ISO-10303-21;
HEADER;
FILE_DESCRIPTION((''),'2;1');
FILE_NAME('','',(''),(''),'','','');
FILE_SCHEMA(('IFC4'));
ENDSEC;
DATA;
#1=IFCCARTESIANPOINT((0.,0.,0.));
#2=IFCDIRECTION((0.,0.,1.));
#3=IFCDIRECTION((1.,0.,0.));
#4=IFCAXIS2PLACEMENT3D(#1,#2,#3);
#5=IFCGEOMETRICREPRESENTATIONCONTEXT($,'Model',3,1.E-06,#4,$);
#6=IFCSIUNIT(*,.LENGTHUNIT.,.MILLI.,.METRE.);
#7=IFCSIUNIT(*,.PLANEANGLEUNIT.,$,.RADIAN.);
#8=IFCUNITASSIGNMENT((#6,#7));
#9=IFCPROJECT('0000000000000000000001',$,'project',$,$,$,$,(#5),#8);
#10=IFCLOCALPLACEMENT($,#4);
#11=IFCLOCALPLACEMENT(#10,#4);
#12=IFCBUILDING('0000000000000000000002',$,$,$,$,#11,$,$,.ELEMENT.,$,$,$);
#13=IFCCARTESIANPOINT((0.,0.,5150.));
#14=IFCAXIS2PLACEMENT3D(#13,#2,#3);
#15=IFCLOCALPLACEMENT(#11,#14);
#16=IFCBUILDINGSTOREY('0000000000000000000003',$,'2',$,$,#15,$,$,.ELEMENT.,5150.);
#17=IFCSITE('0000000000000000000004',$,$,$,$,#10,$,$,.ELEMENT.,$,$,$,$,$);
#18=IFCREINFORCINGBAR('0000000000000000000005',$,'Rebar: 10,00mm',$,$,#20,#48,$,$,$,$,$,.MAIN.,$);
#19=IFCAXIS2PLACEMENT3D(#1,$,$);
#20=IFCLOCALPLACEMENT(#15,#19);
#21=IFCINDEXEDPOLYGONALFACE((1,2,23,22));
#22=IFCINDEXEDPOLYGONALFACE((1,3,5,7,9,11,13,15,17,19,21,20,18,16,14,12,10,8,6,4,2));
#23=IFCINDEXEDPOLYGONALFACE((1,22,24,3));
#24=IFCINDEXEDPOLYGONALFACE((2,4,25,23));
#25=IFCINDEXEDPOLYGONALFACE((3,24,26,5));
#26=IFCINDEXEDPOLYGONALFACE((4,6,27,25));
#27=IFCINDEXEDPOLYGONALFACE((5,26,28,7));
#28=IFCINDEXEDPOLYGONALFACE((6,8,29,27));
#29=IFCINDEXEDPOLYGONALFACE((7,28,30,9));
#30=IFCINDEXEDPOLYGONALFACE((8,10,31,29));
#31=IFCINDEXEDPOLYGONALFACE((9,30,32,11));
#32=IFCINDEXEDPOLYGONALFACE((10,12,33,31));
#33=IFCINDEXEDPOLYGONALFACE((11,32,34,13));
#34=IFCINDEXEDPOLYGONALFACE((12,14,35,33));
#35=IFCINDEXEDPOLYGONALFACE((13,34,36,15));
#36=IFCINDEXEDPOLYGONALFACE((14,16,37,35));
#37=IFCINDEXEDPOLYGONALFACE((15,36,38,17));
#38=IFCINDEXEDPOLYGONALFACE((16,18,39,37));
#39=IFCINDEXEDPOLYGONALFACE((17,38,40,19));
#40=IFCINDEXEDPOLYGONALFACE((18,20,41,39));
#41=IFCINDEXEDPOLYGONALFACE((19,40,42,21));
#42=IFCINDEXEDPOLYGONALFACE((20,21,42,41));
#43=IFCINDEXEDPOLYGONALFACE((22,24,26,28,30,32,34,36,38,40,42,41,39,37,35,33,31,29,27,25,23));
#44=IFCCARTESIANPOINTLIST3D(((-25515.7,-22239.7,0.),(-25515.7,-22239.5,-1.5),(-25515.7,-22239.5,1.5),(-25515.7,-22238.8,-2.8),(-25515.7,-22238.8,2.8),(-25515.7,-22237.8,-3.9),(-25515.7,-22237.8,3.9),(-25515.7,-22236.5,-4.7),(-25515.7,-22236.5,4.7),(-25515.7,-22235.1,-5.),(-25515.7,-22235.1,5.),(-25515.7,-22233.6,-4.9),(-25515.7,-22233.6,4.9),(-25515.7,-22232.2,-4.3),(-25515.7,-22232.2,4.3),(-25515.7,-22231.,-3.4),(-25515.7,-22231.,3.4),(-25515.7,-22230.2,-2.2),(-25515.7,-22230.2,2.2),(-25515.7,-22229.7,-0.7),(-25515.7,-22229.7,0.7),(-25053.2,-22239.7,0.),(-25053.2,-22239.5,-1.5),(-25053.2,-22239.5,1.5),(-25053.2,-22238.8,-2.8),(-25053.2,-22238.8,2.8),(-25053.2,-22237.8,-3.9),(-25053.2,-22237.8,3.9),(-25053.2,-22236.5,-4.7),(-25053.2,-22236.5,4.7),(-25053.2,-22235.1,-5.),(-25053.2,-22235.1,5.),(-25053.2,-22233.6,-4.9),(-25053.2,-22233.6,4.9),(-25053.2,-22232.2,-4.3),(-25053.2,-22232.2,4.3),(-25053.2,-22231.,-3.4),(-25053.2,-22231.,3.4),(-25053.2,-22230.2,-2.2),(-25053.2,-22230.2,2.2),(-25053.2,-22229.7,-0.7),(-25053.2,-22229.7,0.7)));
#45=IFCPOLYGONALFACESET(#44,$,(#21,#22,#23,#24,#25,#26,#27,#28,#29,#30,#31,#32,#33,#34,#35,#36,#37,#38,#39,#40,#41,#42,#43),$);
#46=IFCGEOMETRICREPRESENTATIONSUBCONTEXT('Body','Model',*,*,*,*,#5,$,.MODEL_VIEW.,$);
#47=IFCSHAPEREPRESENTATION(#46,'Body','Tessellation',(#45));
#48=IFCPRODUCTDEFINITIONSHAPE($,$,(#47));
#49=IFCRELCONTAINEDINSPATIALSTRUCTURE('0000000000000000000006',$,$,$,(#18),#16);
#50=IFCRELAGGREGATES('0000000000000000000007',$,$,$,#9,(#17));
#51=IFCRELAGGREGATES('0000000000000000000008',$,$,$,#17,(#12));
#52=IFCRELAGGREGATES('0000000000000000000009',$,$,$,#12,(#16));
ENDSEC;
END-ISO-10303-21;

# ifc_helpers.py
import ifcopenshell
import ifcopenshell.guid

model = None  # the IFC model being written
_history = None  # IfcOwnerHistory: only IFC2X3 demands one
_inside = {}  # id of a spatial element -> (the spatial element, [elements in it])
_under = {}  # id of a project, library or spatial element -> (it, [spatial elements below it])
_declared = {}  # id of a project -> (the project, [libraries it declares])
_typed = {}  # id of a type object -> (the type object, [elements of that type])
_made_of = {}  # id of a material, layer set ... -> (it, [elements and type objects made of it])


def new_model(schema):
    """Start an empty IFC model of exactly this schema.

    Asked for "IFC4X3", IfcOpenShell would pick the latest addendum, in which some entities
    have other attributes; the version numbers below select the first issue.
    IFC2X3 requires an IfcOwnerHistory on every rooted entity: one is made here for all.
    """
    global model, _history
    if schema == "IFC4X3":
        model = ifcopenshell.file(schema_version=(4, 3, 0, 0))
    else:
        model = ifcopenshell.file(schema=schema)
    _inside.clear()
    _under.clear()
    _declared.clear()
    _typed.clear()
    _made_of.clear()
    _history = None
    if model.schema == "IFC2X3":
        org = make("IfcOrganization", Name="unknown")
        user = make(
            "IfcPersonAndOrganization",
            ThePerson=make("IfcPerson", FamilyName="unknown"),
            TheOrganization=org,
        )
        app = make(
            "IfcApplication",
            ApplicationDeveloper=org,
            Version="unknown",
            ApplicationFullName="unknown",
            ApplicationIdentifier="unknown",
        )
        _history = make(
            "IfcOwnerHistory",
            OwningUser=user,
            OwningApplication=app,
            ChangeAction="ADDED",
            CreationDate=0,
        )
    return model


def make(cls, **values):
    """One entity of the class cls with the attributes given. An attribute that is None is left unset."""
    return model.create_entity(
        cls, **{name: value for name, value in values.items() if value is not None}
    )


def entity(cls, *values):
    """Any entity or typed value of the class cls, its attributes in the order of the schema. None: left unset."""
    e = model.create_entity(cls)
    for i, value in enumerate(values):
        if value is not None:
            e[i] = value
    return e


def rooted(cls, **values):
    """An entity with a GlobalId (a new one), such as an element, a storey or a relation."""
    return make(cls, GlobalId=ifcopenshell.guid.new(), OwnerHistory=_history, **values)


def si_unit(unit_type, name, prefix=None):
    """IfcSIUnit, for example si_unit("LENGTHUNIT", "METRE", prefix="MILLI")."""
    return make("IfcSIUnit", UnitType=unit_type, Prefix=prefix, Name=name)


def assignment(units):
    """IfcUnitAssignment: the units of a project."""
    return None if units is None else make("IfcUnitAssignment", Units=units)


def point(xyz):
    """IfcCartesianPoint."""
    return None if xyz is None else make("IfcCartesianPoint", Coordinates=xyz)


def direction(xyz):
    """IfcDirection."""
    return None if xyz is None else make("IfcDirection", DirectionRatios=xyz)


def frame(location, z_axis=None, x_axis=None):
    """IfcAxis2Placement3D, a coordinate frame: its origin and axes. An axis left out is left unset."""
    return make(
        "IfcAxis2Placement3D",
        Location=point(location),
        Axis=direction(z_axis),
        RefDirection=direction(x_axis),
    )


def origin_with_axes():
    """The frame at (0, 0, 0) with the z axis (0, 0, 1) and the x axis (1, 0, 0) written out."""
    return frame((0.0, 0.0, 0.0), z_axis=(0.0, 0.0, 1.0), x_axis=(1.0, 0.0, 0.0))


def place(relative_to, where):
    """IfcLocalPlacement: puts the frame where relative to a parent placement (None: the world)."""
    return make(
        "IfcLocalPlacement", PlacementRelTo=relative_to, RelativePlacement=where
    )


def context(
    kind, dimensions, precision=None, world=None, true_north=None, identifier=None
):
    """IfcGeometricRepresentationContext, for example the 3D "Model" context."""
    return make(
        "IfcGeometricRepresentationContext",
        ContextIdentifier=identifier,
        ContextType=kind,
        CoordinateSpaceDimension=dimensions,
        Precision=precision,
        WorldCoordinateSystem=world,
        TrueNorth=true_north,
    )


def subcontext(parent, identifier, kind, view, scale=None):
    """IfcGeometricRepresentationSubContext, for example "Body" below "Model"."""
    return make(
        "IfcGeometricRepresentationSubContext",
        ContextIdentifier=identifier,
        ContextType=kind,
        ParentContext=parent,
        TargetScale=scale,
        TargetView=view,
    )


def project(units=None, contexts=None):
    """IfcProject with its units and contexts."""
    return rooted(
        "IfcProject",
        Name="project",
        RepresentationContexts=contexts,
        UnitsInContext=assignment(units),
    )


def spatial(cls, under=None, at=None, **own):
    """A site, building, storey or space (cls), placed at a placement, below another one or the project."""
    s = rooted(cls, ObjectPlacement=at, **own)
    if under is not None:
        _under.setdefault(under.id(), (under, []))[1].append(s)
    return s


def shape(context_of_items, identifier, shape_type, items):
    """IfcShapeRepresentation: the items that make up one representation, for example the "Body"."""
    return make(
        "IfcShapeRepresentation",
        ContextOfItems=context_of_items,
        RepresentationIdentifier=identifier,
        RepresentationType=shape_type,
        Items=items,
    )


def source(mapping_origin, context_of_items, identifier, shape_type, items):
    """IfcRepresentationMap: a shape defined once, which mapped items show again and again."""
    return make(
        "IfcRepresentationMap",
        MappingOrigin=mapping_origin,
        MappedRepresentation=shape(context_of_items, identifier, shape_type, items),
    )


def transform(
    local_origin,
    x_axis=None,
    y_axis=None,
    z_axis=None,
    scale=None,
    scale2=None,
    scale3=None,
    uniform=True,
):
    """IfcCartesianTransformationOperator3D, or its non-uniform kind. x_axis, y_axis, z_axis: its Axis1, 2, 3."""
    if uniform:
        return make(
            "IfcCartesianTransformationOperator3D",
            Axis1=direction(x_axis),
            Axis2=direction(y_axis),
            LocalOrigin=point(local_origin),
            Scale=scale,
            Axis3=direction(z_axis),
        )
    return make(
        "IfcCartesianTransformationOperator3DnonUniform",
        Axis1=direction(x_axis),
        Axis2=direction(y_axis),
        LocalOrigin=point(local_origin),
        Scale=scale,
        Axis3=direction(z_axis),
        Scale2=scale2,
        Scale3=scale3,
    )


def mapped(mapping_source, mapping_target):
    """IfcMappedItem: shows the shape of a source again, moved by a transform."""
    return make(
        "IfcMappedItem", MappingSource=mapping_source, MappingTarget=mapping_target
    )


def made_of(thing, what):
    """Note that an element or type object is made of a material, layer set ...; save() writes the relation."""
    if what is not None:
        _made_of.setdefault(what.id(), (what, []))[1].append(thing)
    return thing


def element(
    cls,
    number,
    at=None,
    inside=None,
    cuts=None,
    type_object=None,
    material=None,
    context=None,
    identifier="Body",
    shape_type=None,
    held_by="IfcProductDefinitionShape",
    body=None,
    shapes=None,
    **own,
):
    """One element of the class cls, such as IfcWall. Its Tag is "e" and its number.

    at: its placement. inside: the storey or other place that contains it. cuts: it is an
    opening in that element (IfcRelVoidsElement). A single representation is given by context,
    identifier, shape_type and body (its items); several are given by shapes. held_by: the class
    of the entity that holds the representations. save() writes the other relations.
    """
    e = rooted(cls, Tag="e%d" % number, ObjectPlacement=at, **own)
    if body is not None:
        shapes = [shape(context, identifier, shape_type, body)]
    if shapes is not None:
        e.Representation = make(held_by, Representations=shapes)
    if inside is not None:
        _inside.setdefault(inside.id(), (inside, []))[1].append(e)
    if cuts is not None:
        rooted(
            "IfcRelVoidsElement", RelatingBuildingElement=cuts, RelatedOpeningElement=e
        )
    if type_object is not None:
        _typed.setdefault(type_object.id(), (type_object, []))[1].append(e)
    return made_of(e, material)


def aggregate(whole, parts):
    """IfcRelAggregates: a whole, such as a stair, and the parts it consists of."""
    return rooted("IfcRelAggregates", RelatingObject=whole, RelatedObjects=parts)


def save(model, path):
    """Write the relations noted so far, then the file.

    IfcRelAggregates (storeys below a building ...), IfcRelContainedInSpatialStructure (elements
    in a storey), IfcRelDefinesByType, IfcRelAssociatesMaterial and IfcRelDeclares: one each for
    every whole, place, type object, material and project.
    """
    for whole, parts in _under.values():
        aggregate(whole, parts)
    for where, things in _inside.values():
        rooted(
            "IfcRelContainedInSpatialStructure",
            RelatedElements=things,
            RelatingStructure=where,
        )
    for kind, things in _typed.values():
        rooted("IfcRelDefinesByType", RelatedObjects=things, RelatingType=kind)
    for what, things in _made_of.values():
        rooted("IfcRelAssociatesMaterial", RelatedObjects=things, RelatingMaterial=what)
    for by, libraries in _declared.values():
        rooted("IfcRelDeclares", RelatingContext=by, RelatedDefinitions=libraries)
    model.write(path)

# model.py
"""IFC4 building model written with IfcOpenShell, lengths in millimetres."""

from ifc_helpers import new_model, entity, si_unit, frame, origin_with_axes, place, context, subcontext, project, spatial, source, transform, mapped, element, save


model = new_model("IFC4")

# Units and contexts
model_context = context("Model", 3, precision=1e-06, world=origin_with_axes())
body_context = subcontext(model_context, "Body", "Model", "MODEL_VIEW")
ifc_project = project(units=[si_unit("LENGTHUNIT", "METRE", prefix="MILLI"), si_unit("PLANEANGLEUNIT", "RADIAN")], contexts=[model_context])

# Site, building, storey
site_placement = place(None, origin_with_axes())
site = spatial("IfcSite", under=ifc_project, at=site_placement, CompositionType="ELEMENT")
building_placement = place(site_placement, origin_with_axes())
building = spatial("IfcBuilding", under=site, at=building_placement, CompositionType="ELEMENT")
storey_placement = place(building_placement, frame((0.0, 0.0, 5150.0), z_axis=(0.0, 0.0, 1.0), x_axis=(1.0, 0.0, 0.0)))
storey = spatial("IfcBuildingStorey", under=building, at=storey_placement, Name="2", CompositionType="ELEMENT", Elevation=5150.0)

# Reinforcing bar
shared_shape_1 = source(origin_with_axes(), body_context, "Body", "AdvancedSweptSolid", [
    entity("IfcSweptDiskSolid", entity("IfcIndexedPolyCurve", entity("IfcCartesianPointList3D", [[0.0, 0.0, 0.0], [462.5, 0.0, 0.0]]), [entity("IfcLineIndex", [1, 2])]), 5.0),
])
reinforcing_bar_1_placement = place(storey_placement, origin_with_axes())
element("IfcReinforcingBar", 1, at=reinforcing_bar_1_placement, inside=storey, Name="Rebar: 10,00mm", PredefinedType="MAIN", context=body_context, shape_type="MappedRepresentation", body=[
    mapped(shared_shape_1, transform((-25053.2, -22234.7, 0.0), x_axis=(-1.0, 0.0, 0.0), y_axis=(0.0, -1.0, 0.0), z_axis=(0.0, 0.0, 1.0), scale=1.0)),
])

save(model, "model.ifc")
